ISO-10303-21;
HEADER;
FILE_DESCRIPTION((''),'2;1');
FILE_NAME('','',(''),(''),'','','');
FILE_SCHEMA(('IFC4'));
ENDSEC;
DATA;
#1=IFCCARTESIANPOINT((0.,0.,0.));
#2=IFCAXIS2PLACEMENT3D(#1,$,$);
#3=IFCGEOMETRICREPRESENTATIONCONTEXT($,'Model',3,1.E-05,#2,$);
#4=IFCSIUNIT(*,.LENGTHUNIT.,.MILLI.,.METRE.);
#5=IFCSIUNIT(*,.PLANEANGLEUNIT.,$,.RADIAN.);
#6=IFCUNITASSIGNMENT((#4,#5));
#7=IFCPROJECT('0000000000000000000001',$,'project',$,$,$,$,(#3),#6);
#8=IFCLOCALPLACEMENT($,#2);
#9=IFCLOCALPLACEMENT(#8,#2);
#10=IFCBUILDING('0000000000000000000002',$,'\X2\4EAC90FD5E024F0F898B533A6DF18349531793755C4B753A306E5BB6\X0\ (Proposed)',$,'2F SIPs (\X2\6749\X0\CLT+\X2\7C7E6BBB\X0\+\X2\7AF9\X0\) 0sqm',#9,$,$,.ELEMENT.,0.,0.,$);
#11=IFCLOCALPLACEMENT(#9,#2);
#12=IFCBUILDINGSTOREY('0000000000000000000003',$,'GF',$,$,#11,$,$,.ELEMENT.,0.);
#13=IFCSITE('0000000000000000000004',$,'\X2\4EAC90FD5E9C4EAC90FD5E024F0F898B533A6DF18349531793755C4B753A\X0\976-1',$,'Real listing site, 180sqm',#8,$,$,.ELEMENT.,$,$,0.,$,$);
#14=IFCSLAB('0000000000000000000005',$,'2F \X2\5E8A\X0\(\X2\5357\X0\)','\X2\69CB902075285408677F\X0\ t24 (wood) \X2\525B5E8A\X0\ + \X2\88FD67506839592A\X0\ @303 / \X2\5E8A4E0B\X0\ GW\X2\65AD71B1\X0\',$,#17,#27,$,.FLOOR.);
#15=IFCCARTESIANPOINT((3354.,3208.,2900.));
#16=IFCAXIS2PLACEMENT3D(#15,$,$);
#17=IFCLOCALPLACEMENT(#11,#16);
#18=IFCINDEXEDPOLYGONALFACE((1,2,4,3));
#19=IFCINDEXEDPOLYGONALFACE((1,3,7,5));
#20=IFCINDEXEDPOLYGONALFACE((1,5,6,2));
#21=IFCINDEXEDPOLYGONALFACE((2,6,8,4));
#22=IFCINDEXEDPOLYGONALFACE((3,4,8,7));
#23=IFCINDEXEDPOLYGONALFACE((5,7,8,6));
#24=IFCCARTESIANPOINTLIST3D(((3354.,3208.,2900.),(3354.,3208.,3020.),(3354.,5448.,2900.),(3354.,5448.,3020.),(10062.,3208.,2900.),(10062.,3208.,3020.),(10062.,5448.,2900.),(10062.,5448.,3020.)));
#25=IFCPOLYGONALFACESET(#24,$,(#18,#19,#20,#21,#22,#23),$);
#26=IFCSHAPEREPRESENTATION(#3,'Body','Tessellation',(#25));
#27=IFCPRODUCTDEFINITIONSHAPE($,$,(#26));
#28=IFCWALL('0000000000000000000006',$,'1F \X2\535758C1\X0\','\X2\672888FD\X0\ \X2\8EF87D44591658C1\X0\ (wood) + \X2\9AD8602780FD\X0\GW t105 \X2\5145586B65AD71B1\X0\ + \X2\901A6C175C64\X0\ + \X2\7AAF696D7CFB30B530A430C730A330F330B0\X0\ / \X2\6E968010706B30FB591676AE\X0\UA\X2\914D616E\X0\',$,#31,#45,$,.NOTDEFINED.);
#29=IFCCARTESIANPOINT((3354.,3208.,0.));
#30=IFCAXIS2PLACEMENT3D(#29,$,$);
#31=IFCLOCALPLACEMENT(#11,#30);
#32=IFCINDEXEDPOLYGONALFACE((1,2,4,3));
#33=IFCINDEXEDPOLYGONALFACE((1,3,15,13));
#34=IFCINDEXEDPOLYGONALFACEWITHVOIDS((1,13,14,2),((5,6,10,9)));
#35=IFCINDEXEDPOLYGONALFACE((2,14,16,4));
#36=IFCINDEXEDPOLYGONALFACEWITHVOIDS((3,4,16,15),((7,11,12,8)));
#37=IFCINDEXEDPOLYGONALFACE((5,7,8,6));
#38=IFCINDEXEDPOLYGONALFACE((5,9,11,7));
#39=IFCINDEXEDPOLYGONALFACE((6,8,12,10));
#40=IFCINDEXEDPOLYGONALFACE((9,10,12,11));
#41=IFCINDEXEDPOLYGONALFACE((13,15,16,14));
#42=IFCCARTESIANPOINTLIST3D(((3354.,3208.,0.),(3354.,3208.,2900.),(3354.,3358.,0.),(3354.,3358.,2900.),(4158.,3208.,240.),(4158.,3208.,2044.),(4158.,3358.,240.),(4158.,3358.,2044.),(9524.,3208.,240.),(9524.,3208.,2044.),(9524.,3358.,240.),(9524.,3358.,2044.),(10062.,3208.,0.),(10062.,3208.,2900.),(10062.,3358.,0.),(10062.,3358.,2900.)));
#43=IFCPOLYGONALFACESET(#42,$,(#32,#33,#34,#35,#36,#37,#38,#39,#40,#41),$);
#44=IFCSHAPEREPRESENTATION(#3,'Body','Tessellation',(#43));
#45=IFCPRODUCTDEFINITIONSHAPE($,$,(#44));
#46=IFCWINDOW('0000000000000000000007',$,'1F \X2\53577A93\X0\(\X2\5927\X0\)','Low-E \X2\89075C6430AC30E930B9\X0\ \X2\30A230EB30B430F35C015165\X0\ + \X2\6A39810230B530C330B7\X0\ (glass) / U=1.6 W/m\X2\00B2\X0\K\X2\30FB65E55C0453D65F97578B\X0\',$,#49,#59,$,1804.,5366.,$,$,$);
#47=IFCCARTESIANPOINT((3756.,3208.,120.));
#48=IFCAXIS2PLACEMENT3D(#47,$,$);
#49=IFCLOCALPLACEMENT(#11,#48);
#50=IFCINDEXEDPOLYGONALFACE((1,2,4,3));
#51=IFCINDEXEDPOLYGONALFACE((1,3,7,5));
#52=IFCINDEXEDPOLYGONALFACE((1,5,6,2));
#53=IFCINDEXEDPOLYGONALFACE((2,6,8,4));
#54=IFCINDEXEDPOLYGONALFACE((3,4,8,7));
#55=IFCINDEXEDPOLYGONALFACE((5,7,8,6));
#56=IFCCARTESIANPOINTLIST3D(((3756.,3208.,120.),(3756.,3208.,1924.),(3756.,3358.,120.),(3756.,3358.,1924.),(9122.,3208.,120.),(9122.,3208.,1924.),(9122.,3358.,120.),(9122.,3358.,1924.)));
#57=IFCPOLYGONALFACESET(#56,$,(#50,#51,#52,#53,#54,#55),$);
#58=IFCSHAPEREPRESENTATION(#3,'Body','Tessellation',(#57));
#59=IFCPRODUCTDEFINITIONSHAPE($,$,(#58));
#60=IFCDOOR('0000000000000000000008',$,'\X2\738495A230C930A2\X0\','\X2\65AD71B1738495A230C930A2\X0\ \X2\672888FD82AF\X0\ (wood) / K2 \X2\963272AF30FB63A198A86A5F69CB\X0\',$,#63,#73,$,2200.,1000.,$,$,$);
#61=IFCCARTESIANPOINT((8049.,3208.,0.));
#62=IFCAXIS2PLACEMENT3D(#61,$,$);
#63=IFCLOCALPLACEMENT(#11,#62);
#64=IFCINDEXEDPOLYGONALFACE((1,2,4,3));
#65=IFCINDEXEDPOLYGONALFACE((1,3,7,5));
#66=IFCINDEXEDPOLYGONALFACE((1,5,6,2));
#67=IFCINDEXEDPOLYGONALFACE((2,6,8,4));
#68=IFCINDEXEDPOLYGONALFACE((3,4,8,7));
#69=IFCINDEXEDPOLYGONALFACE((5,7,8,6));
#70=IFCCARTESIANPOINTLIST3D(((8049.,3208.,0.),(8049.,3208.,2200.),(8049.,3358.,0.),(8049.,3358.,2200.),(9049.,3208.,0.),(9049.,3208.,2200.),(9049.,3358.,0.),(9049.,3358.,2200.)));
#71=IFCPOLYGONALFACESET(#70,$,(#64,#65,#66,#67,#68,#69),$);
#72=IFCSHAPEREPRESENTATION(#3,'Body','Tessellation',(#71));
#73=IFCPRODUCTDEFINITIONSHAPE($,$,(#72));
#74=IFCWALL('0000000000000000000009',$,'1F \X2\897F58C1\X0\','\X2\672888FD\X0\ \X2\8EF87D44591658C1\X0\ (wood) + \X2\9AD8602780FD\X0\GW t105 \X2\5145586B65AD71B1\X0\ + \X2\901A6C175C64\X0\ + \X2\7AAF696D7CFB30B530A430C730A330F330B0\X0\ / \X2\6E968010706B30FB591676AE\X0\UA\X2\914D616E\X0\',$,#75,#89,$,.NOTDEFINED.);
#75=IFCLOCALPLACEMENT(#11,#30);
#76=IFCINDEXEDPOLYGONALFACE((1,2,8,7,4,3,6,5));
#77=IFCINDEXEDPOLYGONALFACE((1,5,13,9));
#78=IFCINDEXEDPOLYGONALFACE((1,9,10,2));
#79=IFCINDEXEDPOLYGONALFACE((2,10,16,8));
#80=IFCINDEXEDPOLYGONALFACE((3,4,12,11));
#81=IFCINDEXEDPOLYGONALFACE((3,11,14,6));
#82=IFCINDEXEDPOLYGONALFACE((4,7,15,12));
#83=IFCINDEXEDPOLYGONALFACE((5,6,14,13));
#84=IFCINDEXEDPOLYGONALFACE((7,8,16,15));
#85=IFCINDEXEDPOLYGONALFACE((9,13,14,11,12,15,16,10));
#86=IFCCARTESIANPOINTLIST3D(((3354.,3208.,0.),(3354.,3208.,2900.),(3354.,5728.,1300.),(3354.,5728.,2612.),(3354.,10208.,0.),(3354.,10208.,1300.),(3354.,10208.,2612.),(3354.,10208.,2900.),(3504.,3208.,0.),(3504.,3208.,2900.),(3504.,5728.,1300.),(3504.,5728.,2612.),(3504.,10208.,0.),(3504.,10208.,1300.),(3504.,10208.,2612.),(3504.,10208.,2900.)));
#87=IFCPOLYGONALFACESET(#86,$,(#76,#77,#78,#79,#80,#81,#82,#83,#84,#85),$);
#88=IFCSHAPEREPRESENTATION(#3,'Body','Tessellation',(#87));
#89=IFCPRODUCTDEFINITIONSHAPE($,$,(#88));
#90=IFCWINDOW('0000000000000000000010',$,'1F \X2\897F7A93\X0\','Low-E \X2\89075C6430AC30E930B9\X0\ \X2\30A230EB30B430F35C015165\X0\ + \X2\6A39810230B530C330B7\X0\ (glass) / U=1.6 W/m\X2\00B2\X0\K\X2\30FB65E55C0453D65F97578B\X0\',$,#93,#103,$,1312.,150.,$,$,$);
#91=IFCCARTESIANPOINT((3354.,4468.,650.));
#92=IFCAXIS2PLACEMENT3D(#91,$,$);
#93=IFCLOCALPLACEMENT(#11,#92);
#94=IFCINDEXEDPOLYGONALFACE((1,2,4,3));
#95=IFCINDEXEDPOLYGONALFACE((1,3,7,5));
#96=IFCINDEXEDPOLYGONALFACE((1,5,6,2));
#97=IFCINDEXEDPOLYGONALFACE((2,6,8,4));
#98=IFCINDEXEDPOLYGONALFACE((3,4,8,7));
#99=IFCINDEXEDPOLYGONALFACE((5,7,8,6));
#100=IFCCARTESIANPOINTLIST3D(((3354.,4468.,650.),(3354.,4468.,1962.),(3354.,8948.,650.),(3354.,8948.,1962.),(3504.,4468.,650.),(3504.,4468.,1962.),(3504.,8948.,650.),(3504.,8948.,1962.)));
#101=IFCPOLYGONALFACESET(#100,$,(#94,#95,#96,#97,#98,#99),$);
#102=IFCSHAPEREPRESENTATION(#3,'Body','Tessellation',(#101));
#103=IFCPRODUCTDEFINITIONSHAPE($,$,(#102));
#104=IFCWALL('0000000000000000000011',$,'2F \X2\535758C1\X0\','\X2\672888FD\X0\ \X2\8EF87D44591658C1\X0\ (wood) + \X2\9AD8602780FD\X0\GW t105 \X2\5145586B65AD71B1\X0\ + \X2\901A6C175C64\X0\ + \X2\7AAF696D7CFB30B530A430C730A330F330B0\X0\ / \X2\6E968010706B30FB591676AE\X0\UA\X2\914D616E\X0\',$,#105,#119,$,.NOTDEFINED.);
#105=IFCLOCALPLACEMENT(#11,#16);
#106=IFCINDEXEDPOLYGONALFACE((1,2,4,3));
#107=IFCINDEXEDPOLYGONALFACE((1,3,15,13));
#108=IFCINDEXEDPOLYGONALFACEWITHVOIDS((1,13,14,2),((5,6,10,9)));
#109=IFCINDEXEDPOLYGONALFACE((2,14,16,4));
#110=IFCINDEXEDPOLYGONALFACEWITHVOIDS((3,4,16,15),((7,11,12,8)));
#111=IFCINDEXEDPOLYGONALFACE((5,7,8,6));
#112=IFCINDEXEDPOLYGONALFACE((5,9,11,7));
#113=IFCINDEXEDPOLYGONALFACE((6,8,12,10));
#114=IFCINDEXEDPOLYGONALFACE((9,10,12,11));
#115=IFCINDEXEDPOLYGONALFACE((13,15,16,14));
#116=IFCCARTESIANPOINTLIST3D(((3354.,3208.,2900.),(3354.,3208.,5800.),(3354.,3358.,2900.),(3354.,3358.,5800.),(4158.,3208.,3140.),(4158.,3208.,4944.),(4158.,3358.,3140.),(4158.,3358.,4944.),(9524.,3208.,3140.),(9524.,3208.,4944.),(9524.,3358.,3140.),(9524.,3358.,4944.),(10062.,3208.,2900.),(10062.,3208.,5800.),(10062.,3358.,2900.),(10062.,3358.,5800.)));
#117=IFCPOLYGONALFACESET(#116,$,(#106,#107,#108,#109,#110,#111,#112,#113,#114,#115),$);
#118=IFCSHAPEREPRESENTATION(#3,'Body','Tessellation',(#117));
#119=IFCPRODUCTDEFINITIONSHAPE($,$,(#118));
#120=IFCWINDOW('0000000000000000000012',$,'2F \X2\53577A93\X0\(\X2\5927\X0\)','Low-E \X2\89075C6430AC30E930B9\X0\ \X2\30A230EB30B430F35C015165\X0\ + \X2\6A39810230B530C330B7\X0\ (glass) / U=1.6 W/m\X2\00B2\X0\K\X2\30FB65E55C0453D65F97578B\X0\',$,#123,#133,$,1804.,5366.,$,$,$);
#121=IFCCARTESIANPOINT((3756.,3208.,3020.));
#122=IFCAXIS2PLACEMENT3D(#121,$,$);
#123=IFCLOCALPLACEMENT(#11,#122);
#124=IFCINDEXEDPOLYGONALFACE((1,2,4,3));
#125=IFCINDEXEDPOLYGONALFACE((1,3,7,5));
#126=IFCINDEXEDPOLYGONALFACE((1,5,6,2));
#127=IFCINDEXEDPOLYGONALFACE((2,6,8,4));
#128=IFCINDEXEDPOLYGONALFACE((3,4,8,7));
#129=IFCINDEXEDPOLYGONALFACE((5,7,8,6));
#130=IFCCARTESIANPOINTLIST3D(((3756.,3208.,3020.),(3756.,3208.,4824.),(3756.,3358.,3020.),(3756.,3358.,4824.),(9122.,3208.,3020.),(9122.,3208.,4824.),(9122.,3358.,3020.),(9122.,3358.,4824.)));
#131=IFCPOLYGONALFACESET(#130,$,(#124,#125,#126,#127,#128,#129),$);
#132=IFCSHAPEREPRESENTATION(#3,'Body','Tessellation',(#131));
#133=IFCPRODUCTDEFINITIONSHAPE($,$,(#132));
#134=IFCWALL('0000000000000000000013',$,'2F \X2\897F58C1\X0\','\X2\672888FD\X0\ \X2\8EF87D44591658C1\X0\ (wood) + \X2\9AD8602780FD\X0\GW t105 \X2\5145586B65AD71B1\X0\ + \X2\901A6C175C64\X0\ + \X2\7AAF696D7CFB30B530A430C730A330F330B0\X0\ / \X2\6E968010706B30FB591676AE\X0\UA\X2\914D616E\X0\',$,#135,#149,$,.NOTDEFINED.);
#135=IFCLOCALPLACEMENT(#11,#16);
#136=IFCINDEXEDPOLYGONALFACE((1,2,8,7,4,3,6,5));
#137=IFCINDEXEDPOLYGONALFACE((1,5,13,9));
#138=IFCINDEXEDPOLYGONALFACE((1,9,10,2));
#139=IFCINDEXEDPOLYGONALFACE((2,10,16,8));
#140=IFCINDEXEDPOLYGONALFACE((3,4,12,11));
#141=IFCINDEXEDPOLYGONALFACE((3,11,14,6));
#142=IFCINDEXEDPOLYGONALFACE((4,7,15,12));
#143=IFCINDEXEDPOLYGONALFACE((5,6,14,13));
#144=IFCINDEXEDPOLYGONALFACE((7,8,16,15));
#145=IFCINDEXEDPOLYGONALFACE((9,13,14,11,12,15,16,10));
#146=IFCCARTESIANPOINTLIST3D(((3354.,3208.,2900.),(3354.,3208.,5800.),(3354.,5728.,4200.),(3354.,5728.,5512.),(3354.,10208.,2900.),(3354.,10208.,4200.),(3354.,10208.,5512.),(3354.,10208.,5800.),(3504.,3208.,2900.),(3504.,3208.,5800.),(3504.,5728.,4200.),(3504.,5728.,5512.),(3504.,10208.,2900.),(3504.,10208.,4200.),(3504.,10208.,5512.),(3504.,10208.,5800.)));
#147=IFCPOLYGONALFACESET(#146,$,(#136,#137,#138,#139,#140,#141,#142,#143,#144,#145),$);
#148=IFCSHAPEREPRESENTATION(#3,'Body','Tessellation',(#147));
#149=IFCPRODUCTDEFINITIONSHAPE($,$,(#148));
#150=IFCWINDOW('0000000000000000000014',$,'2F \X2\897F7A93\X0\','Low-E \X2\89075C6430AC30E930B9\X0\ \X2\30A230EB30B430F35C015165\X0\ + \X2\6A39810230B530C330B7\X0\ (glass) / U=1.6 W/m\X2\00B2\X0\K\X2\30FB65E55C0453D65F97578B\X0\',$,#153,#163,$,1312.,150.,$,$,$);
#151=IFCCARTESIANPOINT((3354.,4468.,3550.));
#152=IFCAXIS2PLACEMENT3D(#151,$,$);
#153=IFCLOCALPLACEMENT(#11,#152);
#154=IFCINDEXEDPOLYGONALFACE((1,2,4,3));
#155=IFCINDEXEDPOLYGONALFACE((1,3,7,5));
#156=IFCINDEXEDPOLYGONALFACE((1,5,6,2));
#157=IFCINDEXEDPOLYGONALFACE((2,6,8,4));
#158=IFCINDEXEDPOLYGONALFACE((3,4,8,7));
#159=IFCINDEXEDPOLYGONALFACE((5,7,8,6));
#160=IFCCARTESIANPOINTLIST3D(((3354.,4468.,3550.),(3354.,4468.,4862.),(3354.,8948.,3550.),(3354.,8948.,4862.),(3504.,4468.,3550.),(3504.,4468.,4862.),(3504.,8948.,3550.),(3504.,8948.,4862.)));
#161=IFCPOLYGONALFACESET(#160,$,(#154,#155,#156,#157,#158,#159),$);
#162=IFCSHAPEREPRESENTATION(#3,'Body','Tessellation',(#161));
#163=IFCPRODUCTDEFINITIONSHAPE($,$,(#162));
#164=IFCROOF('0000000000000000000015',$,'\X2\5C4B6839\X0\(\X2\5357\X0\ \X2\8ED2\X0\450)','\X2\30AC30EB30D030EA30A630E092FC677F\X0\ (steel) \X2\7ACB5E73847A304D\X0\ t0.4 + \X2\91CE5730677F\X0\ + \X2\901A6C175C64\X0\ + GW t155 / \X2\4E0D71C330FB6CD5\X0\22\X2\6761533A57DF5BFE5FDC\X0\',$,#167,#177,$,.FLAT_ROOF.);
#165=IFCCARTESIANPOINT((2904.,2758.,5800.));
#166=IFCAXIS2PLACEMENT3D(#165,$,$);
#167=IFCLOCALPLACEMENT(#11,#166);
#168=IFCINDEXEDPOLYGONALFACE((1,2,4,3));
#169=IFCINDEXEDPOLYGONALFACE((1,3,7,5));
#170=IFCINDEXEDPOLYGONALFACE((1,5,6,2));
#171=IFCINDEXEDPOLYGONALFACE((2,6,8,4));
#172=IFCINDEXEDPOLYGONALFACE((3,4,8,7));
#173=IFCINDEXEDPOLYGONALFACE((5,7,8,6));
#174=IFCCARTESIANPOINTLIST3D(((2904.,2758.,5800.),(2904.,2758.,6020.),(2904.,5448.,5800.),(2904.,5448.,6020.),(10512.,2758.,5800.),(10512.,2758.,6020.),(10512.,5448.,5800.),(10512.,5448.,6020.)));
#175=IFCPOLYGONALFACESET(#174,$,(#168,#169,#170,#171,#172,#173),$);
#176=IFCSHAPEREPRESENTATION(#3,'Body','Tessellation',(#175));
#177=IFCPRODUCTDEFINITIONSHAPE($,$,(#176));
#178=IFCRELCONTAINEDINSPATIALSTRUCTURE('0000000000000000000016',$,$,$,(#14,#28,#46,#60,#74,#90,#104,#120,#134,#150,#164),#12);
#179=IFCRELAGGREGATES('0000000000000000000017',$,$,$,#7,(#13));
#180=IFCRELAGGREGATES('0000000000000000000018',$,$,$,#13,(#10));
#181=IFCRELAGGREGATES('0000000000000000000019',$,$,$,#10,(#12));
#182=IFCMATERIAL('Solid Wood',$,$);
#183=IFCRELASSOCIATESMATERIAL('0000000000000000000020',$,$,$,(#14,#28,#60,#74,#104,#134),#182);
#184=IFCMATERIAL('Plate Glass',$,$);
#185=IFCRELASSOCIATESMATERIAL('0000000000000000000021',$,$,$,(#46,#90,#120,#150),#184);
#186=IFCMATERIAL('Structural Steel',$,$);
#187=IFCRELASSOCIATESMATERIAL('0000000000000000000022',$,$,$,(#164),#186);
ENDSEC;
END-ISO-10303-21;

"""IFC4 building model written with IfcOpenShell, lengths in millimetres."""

from ifc_helpers import new_model, si_unit, frame, frame_2d, origin, place, context, project, spatial, rectangle, extrude, material, element, fill, save


model = new_model("IFC4")

# Units and contexts
model_context = context("Model", 3, precision=1e-05, world=origin())
ifc_project = project(units=[si_unit("LENGTHUNIT", "METRE", prefix="MILLI"), si_unit("PLANEANGLEUNIT", "RADIAN")], contexts=[model_context])

# Site, building, storey
site_placement = place(None, origin())
site = spatial("IfcSite", under=ifc_project, at=site_placement, Name="京都府京都市伏見区深草北鍵屋町976-1", ObjectType="Real listing site, 180sqm", CompositionType="ELEMENT", RefElevation=0.0)
building_placement = place(site_placement, origin())
building = spatial("IfcBuilding", under=site, at=building_placement, Name="京都市伏見区深草北鍵屋町の家 (Proposed)", ObjectType="2F SIPs (杉CLT+籾殻+竹) 0sqm", CompositionType="ELEMENT", ElevationOfRefHeight=0.0, ElevationOfTerrain=0.0)
storey_placement = place(building_placement, origin())
storey = spatial("IfcBuildingStorey", under=building, at=storey_placement, Name="GF", CompositionType="ELEMENT", Elevation=0.0)

# Slab
ifc_material_1 = material(Name="Solid Wood")
slab_1_placement = place(storey_placement, frame((3354.0, 3208.0, 2900.0)))
element("IfcSlab", 1, at=slab_1_placement, inside=storey, material=ifc_material_1, Name="2F 床(南)", Description="構造用合板 t24 (wood) 剛床 + 製材根太 @303 / 床下 GW断熱", PredefinedType="FLOOR", context=model_context, shape_type="SweptSolid", body=[
    extrude(rectangle(XDim=6708.0, YDim=2240.0, at=frame_2d((3354.0, 1120.0))), frame((3354.0, 3208.0, 2900.0)), (0.0, 0.0, 1.0), 120.0),
])

# Wall, openings, window, door
wall_1_placement = place(storey_placement, frame((3354.0, 3208.0, 0.0)))
wall_1 = element("IfcWall", 2, at=wall_1_placement, inside=storey, material=ifc_material_1, Name="1F 南壁", Description="木製 軸組外壁 (wood) + 高性能GW t105 充填断熱 + 通気層 + 窯業系サイディング / 準耐火・外皮UA配慮", PredefinedType="NOTDEFINED", context=model_context, shape_type="SweptSolid", body=[
    extrude(rectangle(XDim=6708.0, YDim=150.0, at=frame_2d((3354.0, 75.0))), frame((3354.0, 3208.0, 0.0)), (0.0, 0.0, 1.0), 2900.0),
])
opening_1_placement = place(storey_placement, frame((3756.0, 3208.0, 120.0)))
opening_1 = element("IfcOpeningElement", 3, at=opening_1_placement, cuts=wall_1, PredefinedType="NOTDEFINED", context=model_context, shape_type="SweptSolid", body=[
    extrude(rectangle(XDim=5366.0, YDim=150.0, at=frame_2d((2683.0, 75.0))), frame((3756.0, 3208.0, 120.0)), (0.0, 0.0, 1.0), 1804.0),
])
opening_2_placement = place(storey_placement, frame((8049.0, 3208.0, 0.0)))
opening_2 = element("IfcOpeningElement", 4, at=opening_2_placement, cuts=wall_1, PredefinedType="NOTDEFINED", context=model_context, shape_type="SweptSolid", body=[
    extrude(rectangle(XDim=1000.0, YDim=150.0, at=frame_2d((500.0, 75.0))), frame((8049.0, 3208.0, 0.0)), (0.0, 0.0, 1.0), 2200.0),
])
ifc_material_2 = material(Name="Plate Glass")
window_1_placement = place(storey_placement, frame((3756.0, 3208.0, 120.0)))
window_1 = element("IfcWindow", 5, at=window_1_placement, inside=storey, material=ifc_material_2, Name="1F 南窓(大)", Description="Low-E 複層ガラス アルゴン封入 + 樹脂サッシ (glass) / U=1.6 W/m²K・日射取得型", OverallHeight=1804.0, OverallWidth=5366.0, context=model_context, shape_type="SweptSolid", body=[
    extrude(rectangle(XDim=5366.0, YDim=150.0, at=frame_2d((2683.0, 75.0))), frame((3756.0, 3208.0, 120.0)), (0.0, 0.0, 1.0), 1804.0),
])
fill(opening_1, window_1)
door_placement = place(storey_placement, frame((8049.0, 3208.0, 0.0)))
door = element("IfcDoor", 6, at=door_placement, inside=storey, material=ifc_material_1, Name="玄関ドア", Description="断熱玄関ドア 木製芯 (wood) / K2 防犯・採風機構", OverallHeight=2200.0, OverallWidth=1000.0, context=model_context, shape_type="SweptSolid", body=[
    extrude(rectangle(XDim=1000.0, YDim=150.0, at=frame_2d((500.0, 75.0))), frame((8049.0, 3208.0, 0.0)), (0.0, 0.0, 1.0), 2200.0),
])
fill(opening_2, door)

# Walls, openings, windows
wall_2_placement = place(storey_placement, frame((3354.0, 3208.0, 0.0)))
wall_2 = element("IfcWall", 7, at=wall_2_placement, inside=storey, material=ifc_material_1, Name="1F 西壁", Description="木製 軸組外壁 (wood) + 高性能GW t105 充填断熱 + 通気層 + 窯業系サイディング / 準耐火・外皮UA配慮", PredefinedType="NOTDEFINED", context=model_context, shape_type="SweptSolid", body=[
    extrude(rectangle(XDim=150.0, YDim=7000.0, at=frame_2d((75.0, 3500.0))), frame((3354.0, 3208.0, 0.0)), (0.0, 0.0, 1.0), 2900.0),
])
opening_3_placement = place(storey_placement, frame((3354.0, 4468.0, 650.0)))
opening_3 = element("IfcOpeningElement", 8, at=opening_3_placement, cuts=wall_2, PredefinedType="NOTDEFINED", context=model_context, shape_type="SweptSolid", body=[
    extrude(rectangle(XDim=150.0, YDim=4480.0, at=frame_2d((75.0, 2240.0))), frame((3354.0, 4468.0, 650.0)), (0.0, 0.0, 1.0), 1312.0),
])
window_2_placement = place(storey_placement, frame((3354.0, 4468.0, 650.0)))
window_2 = element("IfcWindow", 9, at=window_2_placement, inside=storey, material=ifc_material_2, Name="1F 西窓", Description="Low-E 複層ガラス アルゴン封入 + 樹脂サッシ (glass) / U=1.6 W/m²K・日射取得型", OverallHeight=1312.0, OverallWidth=150.0, context=model_context, shape_type="SweptSolid", body=[
    extrude(rectangle(XDim=150.0, YDim=4480.0, at=frame_2d((75.0, 2240.0))), frame((3354.0, 4468.0, 650.0)), (0.0, 0.0, 1.0), 1312.0),
])
fill(opening_3, window_2)
wall_3_placement = place(storey_placement, frame((3354.0, 3208.0, 2900.0)))
wall_3 = element("IfcWall", 10, at=wall_3_placement, inside=storey, material=ifc_material_1, Name="2F 南壁", Description="木製 軸組外壁 (wood) + 高性能GW t105 充填断熱 + 通気層 + 窯業系サイディング / 準耐火・外皮UA配慮", PredefinedType="NOTDEFINED", context=model_context, shape_type="SweptSolid", body=[
    extrude(rectangle(XDim=6708.0, YDim=150.0, at=frame_2d((3354.0, 75.0))), frame((3354.0, 3208.0, 2900.0)), (0.0, 0.0, 1.0), 2900.0),
])
opening_4_placement = place(storey_placement, frame((3756.0, 3208.0, 3020.0)))
opening_4 = element("IfcOpeningElement", 11, at=opening_4_placement, cuts=wall_3, PredefinedType="NOTDEFINED", context=model_context, shape_type="SweptSolid", body=[
    extrude(rectangle(XDim=5366.0, YDim=150.0, at=frame_2d((2683.0, 75.0))), frame((3756.0, 3208.0, 3020.0)), (0.0, 0.0, 1.0), 1804.0),
])
window_3_placement = place(storey_placement, frame((3756.0, 3208.0, 3020.0)))
window_3 = element("IfcWindow", 12, at=window_3_placement, inside=storey, material=ifc_material_2, Name="2F 南窓(大)", Description="Low-E 複層ガラス アルゴン封入 + 樹脂サッシ (glass) / U=1.6 W/m²K・日射取得型", OverallHeight=1804.0, OverallWidth=5366.0, context=model_context, shape_type="SweptSolid", body=[
    extrude(rectangle(XDim=5366.0, YDim=150.0, at=frame_2d((2683.0, 75.0))), frame((3756.0, 3208.0, 3020.0)), (0.0, 0.0, 1.0), 1804.0),
])
fill(opening_4, window_3)
wall_4_placement = place(storey_placement, frame((3354.0, 3208.0, 2900.0)))
wall_4 = element("IfcWall", 13, at=wall_4_placement, inside=storey, material=ifc_material_1, Name="2F 西壁", Description="木製 軸組外壁 (wood) + 高性能GW t105 充填断熱 + 通気層 + 窯業系サイディング / 準耐火・外皮UA配慮", PredefinedType="NOTDEFINED", context=model_context, shape_type="SweptSolid", body=[
    extrude(rectangle(XDim=150.0, YDim=7000.0, at=frame_2d((75.0, 3500.0))), frame((3354.0, 3208.0, 2900.0)), (0.0, 0.0, 1.0), 2900.0),
])
opening_5_placement = place(storey_placement, frame((3354.0, 4468.0, 3550.0)))
opening_5 = element("IfcOpeningElement", 14, at=opening_5_placement, cuts=wall_4, PredefinedType="NOTDEFINED", context=model_context, shape_type="SweptSolid", body=[
    extrude(rectangle(XDim=150.0, YDim=4480.0, at=frame_2d((75.0, 2240.0))), frame((3354.0, 4468.0, 3550.0)), (0.0, 0.0, 1.0), 1312.0),
])
window_4_placement = place(storey_placement, frame((3354.0, 4468.0, 3550.0)))
window_4 = element("IfcWindow", 15, at=window_4_placement, inside=storey, material=ifc_material_2, Name="2F 西窓", Description="Low-E 複層ガラス アルゴン封入 + 樹脂サッシ (glass) / U=1.6 W/m²K・日射取得型", OverallHeight=1312.0, OverallWidth=150.0, context=model_context, shape_type="SweptSolid", body=[
    extrude(rectangle(XDim=150.0, YDim=4480.0, at=frame_2d((75.0, 2240.0))), frame((3354.0, 4468.0, 3550.0)), (0.0, 0.0, 1.0), 1312.0),
])
fill(opening_5, window_4)

# Roof
ifc_material_3 = material(Name="Structural Steel")
roof_1_placement = place(storey_placement, frame((2904.0, 2758.0, 5800.0)))
element("IfcRoof", 16, at=roof_1_placement, inside=storey, material=ifc_material_3, Name="屋根(南 軒450)", Description="ガルバリウム鋼板 (steel) 立平葺き t0.4 + 野地板 + 通気層 + GW t155 / 不燃・法22条区域対応", PredefinedType="FLAT_ROOF", context=model_context, shape_type="SweptSolid", body=[
    extrude(rectangle(XDim=7608.0, YDim=2690.0, at=frame_2d((3804.0, 1345.0))), frame((2904.0, 2758.0, 5800.0)), (0.0, 0.0, 1.0), 220.0),
])

save(model, "model.ifc")
